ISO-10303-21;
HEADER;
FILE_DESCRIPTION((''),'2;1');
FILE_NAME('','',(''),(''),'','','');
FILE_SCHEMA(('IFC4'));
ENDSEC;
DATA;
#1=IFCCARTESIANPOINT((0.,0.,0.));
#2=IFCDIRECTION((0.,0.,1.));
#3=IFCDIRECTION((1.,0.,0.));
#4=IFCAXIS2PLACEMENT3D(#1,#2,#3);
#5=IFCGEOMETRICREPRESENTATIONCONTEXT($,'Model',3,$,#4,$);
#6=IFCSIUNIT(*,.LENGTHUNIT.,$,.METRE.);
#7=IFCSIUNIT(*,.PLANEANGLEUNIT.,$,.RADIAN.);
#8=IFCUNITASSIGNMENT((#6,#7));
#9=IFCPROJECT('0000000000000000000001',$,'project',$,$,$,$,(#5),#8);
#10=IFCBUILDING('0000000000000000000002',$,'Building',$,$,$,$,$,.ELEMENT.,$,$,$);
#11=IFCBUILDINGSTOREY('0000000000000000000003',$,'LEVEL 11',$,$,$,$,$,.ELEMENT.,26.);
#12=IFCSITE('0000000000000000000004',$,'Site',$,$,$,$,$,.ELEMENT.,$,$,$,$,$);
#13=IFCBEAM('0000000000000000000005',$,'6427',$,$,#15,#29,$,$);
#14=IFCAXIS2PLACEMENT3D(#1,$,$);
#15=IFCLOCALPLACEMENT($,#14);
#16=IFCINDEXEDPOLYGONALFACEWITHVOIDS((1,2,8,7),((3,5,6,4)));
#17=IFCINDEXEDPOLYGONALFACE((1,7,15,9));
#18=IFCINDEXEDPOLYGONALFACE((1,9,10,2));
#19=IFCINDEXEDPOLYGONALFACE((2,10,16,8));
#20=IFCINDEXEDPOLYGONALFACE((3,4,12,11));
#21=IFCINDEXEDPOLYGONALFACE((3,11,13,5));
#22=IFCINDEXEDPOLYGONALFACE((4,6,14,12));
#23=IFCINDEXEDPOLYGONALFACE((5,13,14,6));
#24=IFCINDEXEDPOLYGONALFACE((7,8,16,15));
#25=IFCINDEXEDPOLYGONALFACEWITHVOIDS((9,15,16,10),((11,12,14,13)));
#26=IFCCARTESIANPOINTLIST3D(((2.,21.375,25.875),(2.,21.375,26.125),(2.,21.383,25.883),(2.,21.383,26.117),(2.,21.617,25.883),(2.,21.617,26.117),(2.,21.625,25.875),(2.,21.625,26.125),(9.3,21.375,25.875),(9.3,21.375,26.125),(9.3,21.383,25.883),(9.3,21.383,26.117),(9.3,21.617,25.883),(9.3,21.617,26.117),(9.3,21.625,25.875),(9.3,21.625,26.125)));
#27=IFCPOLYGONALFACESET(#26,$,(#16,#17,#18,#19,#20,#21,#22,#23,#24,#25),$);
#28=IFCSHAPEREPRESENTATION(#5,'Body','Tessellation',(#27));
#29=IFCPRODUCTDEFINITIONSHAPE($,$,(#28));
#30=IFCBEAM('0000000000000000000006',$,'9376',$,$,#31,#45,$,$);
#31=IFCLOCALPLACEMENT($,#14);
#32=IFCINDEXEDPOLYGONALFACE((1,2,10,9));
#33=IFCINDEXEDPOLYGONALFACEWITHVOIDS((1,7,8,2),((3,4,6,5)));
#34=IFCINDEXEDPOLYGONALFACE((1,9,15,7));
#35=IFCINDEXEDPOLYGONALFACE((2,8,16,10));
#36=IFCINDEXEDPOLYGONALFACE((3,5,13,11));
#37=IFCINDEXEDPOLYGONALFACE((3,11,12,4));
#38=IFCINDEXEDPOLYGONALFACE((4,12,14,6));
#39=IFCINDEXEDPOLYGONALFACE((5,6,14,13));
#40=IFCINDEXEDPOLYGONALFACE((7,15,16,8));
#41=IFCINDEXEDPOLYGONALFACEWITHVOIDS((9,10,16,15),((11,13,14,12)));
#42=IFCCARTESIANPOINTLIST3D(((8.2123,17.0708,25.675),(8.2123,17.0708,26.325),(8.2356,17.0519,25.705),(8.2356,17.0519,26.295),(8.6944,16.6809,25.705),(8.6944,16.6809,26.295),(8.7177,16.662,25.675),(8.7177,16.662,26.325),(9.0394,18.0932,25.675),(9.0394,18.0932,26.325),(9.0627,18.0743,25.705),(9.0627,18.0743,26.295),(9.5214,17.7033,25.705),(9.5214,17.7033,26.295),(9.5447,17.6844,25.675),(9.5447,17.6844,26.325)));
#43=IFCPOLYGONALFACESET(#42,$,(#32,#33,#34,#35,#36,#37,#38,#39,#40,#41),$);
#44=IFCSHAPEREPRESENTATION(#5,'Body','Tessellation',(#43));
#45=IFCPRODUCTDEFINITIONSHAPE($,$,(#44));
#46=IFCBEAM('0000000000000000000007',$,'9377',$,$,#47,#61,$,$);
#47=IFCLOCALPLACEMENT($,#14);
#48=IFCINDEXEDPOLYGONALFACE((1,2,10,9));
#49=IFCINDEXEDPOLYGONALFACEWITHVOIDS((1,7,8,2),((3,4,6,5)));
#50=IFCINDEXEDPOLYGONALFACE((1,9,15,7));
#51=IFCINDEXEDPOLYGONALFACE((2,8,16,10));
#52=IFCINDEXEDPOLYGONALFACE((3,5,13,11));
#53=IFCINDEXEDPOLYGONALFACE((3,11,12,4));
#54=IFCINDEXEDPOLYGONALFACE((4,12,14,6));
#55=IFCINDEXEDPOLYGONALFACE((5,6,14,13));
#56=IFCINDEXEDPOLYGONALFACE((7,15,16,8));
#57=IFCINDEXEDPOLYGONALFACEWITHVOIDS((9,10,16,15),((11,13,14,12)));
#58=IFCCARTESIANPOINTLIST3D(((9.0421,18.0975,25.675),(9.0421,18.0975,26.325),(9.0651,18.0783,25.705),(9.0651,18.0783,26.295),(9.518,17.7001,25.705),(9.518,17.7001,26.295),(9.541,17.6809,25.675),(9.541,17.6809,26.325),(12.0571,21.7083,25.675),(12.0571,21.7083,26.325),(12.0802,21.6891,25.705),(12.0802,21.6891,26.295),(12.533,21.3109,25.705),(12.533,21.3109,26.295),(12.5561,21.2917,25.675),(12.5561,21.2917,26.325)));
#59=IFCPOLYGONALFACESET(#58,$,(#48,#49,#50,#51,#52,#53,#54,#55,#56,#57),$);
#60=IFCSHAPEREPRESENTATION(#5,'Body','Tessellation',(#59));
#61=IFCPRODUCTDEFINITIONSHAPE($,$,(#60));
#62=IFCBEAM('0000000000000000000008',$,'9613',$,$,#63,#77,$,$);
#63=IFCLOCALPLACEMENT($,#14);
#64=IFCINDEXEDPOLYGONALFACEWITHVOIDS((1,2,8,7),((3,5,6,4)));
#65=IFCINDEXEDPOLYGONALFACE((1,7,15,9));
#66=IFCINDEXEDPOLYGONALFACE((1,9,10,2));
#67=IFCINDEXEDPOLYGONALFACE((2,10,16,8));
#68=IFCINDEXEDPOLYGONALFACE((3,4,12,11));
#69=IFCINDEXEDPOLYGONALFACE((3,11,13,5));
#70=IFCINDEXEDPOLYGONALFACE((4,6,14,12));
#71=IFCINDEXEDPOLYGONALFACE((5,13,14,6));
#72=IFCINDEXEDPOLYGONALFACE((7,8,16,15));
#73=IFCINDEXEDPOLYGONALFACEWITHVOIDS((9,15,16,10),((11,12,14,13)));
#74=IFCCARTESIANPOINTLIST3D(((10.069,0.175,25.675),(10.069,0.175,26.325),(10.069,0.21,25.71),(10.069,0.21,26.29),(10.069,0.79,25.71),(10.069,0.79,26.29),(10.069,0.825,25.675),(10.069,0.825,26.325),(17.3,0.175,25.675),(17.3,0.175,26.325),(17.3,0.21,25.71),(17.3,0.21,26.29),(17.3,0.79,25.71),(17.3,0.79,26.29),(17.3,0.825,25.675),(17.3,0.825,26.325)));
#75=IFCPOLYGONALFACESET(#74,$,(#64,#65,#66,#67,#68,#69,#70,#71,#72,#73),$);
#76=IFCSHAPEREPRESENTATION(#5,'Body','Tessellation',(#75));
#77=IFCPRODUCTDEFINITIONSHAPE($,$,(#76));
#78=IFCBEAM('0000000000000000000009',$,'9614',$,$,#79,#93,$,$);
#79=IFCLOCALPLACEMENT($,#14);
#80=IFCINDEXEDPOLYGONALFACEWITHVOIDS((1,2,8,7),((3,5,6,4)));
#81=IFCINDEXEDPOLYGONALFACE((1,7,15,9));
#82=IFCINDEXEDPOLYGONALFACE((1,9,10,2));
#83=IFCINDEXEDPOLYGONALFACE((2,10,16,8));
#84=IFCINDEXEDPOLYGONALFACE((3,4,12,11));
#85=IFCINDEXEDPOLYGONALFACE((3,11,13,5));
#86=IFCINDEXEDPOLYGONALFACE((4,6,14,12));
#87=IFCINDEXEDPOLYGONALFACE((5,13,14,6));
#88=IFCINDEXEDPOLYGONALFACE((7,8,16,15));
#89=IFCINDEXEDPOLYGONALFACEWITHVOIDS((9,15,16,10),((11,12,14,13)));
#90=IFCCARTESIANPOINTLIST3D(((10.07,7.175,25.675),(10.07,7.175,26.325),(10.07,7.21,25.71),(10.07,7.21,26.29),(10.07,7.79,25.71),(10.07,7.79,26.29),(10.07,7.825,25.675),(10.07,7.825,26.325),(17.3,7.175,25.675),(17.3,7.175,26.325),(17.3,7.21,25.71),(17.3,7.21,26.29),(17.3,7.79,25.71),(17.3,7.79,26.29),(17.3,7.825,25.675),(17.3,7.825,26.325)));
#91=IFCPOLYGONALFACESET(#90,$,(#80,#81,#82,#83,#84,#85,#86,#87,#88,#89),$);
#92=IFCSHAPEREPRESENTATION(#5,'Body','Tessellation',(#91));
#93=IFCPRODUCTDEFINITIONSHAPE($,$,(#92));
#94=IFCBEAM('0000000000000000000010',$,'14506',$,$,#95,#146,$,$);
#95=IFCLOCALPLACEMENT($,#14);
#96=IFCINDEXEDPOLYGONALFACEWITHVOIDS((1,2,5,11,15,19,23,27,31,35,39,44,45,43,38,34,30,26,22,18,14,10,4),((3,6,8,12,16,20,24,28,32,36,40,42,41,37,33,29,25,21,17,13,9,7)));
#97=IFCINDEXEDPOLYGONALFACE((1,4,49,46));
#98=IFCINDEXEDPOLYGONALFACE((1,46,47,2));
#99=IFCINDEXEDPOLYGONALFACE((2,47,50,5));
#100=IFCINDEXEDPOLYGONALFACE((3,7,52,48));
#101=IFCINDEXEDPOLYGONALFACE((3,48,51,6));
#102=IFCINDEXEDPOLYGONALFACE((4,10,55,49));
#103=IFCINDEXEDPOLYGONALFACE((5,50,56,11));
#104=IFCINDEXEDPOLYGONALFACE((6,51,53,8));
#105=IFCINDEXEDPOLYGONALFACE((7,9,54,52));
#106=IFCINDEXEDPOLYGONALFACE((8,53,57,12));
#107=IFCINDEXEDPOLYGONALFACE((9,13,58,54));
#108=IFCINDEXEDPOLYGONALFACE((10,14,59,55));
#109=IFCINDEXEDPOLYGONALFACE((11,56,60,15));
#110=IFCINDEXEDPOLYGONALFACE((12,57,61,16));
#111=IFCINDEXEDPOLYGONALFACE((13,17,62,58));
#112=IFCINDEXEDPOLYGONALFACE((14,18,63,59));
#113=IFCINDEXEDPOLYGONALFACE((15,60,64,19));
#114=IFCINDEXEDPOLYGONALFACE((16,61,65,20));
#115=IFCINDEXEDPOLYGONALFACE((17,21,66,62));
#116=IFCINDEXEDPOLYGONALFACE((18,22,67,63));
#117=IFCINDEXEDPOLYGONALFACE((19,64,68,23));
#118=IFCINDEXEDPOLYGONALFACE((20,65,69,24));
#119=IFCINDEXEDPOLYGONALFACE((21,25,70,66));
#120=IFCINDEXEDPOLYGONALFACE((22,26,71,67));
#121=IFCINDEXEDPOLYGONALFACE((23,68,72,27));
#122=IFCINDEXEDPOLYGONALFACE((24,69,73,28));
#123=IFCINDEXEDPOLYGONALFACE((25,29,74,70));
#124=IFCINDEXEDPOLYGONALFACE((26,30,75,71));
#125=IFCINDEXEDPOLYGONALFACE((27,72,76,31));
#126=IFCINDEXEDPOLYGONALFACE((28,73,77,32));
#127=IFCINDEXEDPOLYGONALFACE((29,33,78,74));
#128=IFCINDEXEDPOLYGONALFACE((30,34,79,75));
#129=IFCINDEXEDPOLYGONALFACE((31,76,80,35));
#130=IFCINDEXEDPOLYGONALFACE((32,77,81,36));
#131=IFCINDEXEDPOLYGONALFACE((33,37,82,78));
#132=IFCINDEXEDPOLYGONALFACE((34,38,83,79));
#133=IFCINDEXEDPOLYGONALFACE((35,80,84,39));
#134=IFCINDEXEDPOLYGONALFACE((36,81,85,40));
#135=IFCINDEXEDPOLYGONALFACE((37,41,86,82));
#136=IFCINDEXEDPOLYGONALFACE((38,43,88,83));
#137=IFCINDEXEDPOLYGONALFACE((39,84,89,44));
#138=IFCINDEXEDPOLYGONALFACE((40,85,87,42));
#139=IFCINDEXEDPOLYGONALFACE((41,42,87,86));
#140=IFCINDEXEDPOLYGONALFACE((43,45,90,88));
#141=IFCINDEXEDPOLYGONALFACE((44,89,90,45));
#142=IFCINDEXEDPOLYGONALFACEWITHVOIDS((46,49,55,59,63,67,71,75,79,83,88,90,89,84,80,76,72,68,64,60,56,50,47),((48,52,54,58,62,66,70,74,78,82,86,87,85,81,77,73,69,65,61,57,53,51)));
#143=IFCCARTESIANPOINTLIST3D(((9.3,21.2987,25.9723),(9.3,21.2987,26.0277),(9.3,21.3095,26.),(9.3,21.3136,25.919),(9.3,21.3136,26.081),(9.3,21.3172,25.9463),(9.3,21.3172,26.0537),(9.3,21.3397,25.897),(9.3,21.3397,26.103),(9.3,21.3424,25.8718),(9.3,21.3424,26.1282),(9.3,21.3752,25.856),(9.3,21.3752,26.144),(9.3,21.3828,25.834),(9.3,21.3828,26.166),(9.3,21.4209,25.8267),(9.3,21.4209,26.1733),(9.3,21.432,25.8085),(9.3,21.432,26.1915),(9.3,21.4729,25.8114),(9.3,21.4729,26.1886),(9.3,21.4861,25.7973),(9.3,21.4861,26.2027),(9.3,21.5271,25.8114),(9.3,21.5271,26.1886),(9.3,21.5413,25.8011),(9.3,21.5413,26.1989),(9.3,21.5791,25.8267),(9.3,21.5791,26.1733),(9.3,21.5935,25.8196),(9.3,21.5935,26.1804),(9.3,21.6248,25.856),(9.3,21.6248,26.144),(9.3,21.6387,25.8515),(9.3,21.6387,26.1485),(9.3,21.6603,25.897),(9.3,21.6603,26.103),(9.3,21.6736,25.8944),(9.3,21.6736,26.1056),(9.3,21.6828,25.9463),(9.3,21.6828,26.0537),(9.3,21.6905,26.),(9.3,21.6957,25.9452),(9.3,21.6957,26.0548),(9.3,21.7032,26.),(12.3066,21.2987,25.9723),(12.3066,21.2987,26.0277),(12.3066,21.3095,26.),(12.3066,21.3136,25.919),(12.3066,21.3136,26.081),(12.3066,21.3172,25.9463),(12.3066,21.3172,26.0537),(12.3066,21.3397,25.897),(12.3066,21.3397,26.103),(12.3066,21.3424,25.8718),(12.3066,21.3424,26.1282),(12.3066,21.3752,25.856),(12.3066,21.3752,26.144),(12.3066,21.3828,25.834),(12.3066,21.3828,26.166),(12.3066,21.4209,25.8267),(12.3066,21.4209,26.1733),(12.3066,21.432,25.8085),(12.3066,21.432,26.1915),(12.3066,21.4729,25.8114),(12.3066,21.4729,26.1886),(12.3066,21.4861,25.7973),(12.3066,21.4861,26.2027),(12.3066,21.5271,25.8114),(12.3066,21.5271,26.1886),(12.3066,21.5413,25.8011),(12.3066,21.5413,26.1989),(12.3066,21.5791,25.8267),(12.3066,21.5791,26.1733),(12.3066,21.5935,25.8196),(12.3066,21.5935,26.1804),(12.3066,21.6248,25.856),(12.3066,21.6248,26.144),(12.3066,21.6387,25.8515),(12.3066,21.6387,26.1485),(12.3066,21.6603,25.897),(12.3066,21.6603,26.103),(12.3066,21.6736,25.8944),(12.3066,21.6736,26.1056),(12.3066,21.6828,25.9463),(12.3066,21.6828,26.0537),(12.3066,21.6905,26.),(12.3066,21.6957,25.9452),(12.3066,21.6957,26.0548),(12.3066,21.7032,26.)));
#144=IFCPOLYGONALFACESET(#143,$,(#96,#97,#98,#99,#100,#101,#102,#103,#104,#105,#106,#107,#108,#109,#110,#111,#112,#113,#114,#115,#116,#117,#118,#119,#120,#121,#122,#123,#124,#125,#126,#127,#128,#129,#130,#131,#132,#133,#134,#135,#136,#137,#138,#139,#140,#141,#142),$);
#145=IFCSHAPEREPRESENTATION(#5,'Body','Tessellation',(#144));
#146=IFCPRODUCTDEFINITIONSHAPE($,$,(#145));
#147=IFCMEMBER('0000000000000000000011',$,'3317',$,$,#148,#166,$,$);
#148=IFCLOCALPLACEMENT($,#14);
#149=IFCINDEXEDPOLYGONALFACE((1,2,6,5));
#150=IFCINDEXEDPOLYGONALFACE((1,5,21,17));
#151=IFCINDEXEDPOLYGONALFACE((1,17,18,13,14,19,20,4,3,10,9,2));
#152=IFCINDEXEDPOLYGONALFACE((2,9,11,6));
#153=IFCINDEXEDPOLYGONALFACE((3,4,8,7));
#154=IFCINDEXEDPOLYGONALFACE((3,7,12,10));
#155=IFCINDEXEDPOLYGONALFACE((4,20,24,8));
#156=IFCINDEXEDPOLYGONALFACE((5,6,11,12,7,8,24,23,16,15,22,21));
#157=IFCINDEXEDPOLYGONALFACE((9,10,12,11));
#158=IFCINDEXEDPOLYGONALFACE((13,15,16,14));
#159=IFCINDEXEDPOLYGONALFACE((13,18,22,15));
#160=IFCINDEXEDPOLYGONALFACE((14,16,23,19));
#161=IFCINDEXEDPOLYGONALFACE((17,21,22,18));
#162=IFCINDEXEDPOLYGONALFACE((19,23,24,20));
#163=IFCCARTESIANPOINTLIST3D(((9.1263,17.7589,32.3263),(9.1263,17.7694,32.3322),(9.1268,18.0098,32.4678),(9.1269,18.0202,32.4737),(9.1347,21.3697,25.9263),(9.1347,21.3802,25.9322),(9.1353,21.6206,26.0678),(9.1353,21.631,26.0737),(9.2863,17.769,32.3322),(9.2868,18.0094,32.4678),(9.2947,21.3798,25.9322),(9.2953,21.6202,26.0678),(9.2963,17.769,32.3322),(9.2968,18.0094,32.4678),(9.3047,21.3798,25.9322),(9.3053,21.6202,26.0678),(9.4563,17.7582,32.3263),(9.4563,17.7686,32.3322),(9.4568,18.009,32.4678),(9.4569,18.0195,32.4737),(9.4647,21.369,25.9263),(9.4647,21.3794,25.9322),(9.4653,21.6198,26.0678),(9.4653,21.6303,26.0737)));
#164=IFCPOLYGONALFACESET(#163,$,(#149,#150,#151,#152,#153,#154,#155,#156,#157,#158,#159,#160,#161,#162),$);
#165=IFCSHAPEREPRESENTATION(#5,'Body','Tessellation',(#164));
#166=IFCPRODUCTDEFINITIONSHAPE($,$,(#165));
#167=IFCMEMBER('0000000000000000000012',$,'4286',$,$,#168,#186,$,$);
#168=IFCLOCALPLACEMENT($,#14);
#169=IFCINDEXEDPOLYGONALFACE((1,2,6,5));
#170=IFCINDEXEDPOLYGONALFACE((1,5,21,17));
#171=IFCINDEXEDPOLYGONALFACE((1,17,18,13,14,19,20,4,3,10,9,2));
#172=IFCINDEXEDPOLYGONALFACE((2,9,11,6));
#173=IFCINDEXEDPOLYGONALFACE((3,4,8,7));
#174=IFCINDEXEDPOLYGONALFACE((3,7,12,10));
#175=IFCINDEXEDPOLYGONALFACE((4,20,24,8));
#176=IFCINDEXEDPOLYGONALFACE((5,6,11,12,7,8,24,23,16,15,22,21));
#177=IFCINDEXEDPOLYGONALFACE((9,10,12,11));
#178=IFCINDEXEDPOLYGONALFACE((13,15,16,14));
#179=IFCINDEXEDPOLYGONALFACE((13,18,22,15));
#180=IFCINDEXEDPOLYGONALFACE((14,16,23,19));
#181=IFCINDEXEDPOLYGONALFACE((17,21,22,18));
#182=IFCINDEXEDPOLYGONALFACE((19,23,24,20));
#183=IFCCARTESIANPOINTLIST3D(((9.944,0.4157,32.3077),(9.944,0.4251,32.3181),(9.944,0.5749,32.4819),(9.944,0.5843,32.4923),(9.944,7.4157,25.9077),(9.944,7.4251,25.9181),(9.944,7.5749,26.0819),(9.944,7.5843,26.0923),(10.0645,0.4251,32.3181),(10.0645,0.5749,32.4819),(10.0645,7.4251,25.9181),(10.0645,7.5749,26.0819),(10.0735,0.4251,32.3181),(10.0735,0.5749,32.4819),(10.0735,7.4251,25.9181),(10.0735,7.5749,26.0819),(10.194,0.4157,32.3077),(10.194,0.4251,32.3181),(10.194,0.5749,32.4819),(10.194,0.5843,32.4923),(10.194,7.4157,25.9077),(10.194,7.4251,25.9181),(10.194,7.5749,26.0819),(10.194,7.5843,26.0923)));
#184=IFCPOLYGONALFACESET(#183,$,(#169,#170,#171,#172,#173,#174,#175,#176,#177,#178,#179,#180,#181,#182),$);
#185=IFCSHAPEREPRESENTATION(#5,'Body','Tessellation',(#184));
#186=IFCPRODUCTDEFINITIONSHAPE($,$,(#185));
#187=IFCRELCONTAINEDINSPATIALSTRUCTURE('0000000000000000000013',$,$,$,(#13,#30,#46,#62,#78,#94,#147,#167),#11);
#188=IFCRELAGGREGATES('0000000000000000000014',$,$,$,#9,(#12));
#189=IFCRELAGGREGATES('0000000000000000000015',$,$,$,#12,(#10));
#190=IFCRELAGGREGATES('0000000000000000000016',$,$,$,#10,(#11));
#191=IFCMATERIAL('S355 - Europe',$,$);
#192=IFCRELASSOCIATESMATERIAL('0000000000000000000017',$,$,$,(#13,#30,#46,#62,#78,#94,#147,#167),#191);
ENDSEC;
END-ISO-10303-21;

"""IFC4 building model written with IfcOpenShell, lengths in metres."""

from ifc_helpers import new_model, si_unit, frame, origin_with_axes, origin_2d_with_axis, place, context, project, spatial, hollow_rectangle, hollow_circle, i_section, extrude, material, material_profile, profile_set, profile_usage, element, save


model = new_model("IFC4")

# Units and contexts
model_context = context("Model", 3, world=origin_with_axes())
ifc_project = project(units=[si_unit("LENGTHUNIT", "METRE"), si_unit("PLANEANGLEUNIT", "RADIAN")], contexts=[model_context])

# Site, building, storey
site = spatial("IfcSite", under=ifc_project, Name="Site", CompositionType="ELEMENT")
building = spatial("IfcBuilding", under=site, Name="Building", CompositionType="ELEMENT")
storey = spatial("IfcBuildingStorey", under=building, Name="LEVEL 11", CompositionType="ELEMENT", Elevation=26.0)

# Shared definitions
ifc_material = material(Name="S355 - Europe")

# Beams
ifc_material_profile_1 = material_profile(ifc_material, hollow_rectangle(XDim=0.25, YDim=0.25, WallThickness=0.008, at=origin_2d_with_axis()))
ifc_profile_set_1 = profile_set([ifc_material_profile_1])
ifc_profile_usage_1 = profile_usage(ifc_profile_set_1, cardinal=10)
beam_1_placement = place(None, frame((9.3, 21.5, 26.0), z_axis=(-1.0, 0.0, 0.0), x_axis=(0.0, -1.0, 0.0)))
element("IfcBeam", 1, at=beam_1_placement, inside=storey, material=ifc_profile_usage_1, Name="6427", context=model_context, shape_type="SweptSolid", body=[
    extrude(hollow_rectangle(XDim=0.25, YDim=0.25, WallThickness=0.008, at=origin_2d_with_axis()), origin_with_axes(), (0.0, 0.0, 1.0), 7.3),
])
ifc_material_profile_2 = material_profile(ifc_material, hollow_rectangle(XDim=0.65, YDim=0.65, WallThickness=0.03, at=origin_2d_with_axis()))
ifc_profile_set_2 = profile_set([ifc_material_profile_2])
ifc_profile_usage_2 = profile_usage(ifc_profile_set_2, cardinal=10)
beam_2_placement = place(None, frame((8.465, 16.8664, 26.0), z_axis=(0.62892, 0.77747, 0.0), x_axis=(-0.777826, 0.62848, 0.0)))
element("IfcBeam", 2, at=beam_2_placement, inside=storey, material=ifc_profile_usage_2, Name="9376", context=model_context, shape_type="SweptSolid", body=[
    extrude(hollow_rectangle(XDim=0.65, YDim=0.65, WallThickness=0.03, at=origin_2d_with_axis()), origin_with_axes(), (0.0, 0.0, 1.0), 1.315),
])
ifc_material_profile_3 = material_profile(ifc_material, hollow_rectangle(XDim=0.65, YDim=0.65, WallThickness=0.03, at=origin_2d_with_axis()))
ifc_profile_set_3 = profile_set([ifc_material_profile_3])
ifc_profile_usage_3 = profile_usage(ifc_profile_set_3, cardinal=10)
beam_3_placement = place(None, frame((9.2916, 17.8892, 26.0), z_axis=(0.640942, 0.767589, 0.0), x_axis=(-0.767589, 0.640942, 0.0)))
element("IfcBeam", 3, at=beam_3_placement, inside=storey, material=ifc_profile_usage_3, Name="9377", context=model_context, shape_type="SweptSolid", body=[
    extrude(hollow_rectangle(XDim=0.65, YDim=0.65, WallThickness=0.03, at=origin_2d_with_axis()), origin_with_axes(), (0.0, 0.0, 1.0), 4.7041),
])
ifc_material_profile_4 = material_profile(ifc_material, hollow_rectangle(XDim=0.65, YDim=0.65, WallThickness=0.035, at=origin_2d_with_axis()))
ifc_profile_set_4 = profile_set([ifc_material_profile_4])
ifc_profile_usage_4 = profile_usage(ifc_profile_set_4, cardinal=10)
beam_4_placement = place(None, frame((10.069, 0.5, 26.0), z_axis=(1.0, 0.0, 0.0), x_axis=(0.0, 1.0, 0.0)))
element("IfcBeam", 4, at=beam_4_placement, inside=storey, material=ifc_profile_usage_4, Name="9613", context=model_context, shape_type="SweptSolid", body=[
    extrude(hollow_rectangle(XDim=0.65, YDim=0.65, WallThickness=0.035, at=origin_2d_with_axis()), origin_with_axes(), (0.0, 0.0, 1.0), 7.231),
])
ifc_material_profile_5 = material_profile(ifc_material, hollow_rectangle(XDim=0.65, YDim=0.65, WallThickness=0.035, at=origin_2d_with_axis()))
ifc_profile_set_5 = profile_set([ifc_material_profile_5])
ifc_profile_usage_5 = profile_usage(ifc_profile_set_5, cardinal=10)
beam_5_placement = place(None, frame((10.07, 7.5, 26.0), z_axis=(1.0, 0.0, 0.0), x_axis=(0.0, 1.0, 0.0)))
element("IfcBeam", 5, at=beam_5_placement, inside=storey, material=ifc_profile_usage_5, Name="9614", context=model_context, shape_type="SweptSolid", body=[
    extrude(hollow_rectangle(XDim=0.65, YDim=0.65, WallThickness=0.035, at=origin_2d_with_axis()), origin_with_axes(), (0.0, 0.0, 1.0), 7.23),
])
ifc_material_profile_6 = material_profile(ifc_material, hollow_circle(Radius=0.2032, WallThickness=0.0127, at=origin_2d_with_axis()))
ifc_profile_set_6 = profile_set([ifc_material_profile_6])
ifc_profile_usage_6 = profile_usage(ifc_profile_set_6, cardinal=10)
beam_6_placement = place(None, frame((9.3, 21.5, 26.0), z_axis=(1.0, 0.0, 0.0), x_axis=(0.0, 1.0, 0.0)))
element("IfcBeam", 6, at=beam_6_placement, inside=storey, material=ifc_profile_usage_6, Name="14506", context=model_context, shape_type="SweptSolid", body=[
    extrude(hollow_circle(Radius=0.2032, WallThickness=0.0127, at=origin_2d_with_axis()), origin_with_axes(), (0.0, 0.0, 1.0), 3.0066),
])

# Members
ifc_material_profile_7 = material_profile(ifc_material, i_section(OverallWidth=0.33, OverallDepth=0.3, WebThickness=0.01, FlangeThickness=0.012, at=origin_2d_with_axis()))
ifc_profile_set_7 = profile_set([ifc_material_profile_7])
ifc_profile_usage_7 = profile_usage(ifc_profile_set_7, cardinal=10)
member_1_placement = place(None, frame((9.3, 21.5, 26.0), z_axis=(-0.001149, -0.491377, 0.870946), x_axis=(0.999997, -0.002337, 0.0)))
element("IfcMember", 7, at=member_1_placement, inside=storey, material=ifc_profile_usage_7, Name="3317", context=model_context, shape_type="SweptSolid", body=[
    extrude(i_section(OverallWidth=0.33, OverallDepth=0.3, WebThickness=0.01, FlangeThickness=0.012, at=origin_2d_with_axis()), origin_with_axes(), (0.0, 0.0, 1.0), 7.3483),
])
ifc_material_profile_8 = material_profile(ifc_material, i_section(OverallWidth=0.25, OverallDepth=0.25, WebThickness=0.009, FlangeThickness=0.014, at=origin_2d_with_axis()))
ifc_profile_set_8 = profile_set([ifc_material_profile_8])
ifc_profile_usage_8 = profile_usage(ifc_profile_set_8, cardinal=10)
member_2_placement = place(None, frame((10.069, 0.5, 32.4), z_axis=(0.0, 0.738029, -0.674769), x_axis=(-1.0, 0.0, 0.0)))
element("IfcMember", 8, at=member_2_placement, inside=storey, material=ifc_profile_usage_8, Name="4286", context=model_context, shape_type="SweptSolid", body=[
    extrude(i_section(OverallWidth=0.25, OverallDepth=0.25, WebThickness=0.009, FlangeThickness=0.014, at=origin_2d_with_axis()), origin_with_axes(), (0.0, 0.0, 1.0), 9.4847),
])

save(model, "model.ifc")
